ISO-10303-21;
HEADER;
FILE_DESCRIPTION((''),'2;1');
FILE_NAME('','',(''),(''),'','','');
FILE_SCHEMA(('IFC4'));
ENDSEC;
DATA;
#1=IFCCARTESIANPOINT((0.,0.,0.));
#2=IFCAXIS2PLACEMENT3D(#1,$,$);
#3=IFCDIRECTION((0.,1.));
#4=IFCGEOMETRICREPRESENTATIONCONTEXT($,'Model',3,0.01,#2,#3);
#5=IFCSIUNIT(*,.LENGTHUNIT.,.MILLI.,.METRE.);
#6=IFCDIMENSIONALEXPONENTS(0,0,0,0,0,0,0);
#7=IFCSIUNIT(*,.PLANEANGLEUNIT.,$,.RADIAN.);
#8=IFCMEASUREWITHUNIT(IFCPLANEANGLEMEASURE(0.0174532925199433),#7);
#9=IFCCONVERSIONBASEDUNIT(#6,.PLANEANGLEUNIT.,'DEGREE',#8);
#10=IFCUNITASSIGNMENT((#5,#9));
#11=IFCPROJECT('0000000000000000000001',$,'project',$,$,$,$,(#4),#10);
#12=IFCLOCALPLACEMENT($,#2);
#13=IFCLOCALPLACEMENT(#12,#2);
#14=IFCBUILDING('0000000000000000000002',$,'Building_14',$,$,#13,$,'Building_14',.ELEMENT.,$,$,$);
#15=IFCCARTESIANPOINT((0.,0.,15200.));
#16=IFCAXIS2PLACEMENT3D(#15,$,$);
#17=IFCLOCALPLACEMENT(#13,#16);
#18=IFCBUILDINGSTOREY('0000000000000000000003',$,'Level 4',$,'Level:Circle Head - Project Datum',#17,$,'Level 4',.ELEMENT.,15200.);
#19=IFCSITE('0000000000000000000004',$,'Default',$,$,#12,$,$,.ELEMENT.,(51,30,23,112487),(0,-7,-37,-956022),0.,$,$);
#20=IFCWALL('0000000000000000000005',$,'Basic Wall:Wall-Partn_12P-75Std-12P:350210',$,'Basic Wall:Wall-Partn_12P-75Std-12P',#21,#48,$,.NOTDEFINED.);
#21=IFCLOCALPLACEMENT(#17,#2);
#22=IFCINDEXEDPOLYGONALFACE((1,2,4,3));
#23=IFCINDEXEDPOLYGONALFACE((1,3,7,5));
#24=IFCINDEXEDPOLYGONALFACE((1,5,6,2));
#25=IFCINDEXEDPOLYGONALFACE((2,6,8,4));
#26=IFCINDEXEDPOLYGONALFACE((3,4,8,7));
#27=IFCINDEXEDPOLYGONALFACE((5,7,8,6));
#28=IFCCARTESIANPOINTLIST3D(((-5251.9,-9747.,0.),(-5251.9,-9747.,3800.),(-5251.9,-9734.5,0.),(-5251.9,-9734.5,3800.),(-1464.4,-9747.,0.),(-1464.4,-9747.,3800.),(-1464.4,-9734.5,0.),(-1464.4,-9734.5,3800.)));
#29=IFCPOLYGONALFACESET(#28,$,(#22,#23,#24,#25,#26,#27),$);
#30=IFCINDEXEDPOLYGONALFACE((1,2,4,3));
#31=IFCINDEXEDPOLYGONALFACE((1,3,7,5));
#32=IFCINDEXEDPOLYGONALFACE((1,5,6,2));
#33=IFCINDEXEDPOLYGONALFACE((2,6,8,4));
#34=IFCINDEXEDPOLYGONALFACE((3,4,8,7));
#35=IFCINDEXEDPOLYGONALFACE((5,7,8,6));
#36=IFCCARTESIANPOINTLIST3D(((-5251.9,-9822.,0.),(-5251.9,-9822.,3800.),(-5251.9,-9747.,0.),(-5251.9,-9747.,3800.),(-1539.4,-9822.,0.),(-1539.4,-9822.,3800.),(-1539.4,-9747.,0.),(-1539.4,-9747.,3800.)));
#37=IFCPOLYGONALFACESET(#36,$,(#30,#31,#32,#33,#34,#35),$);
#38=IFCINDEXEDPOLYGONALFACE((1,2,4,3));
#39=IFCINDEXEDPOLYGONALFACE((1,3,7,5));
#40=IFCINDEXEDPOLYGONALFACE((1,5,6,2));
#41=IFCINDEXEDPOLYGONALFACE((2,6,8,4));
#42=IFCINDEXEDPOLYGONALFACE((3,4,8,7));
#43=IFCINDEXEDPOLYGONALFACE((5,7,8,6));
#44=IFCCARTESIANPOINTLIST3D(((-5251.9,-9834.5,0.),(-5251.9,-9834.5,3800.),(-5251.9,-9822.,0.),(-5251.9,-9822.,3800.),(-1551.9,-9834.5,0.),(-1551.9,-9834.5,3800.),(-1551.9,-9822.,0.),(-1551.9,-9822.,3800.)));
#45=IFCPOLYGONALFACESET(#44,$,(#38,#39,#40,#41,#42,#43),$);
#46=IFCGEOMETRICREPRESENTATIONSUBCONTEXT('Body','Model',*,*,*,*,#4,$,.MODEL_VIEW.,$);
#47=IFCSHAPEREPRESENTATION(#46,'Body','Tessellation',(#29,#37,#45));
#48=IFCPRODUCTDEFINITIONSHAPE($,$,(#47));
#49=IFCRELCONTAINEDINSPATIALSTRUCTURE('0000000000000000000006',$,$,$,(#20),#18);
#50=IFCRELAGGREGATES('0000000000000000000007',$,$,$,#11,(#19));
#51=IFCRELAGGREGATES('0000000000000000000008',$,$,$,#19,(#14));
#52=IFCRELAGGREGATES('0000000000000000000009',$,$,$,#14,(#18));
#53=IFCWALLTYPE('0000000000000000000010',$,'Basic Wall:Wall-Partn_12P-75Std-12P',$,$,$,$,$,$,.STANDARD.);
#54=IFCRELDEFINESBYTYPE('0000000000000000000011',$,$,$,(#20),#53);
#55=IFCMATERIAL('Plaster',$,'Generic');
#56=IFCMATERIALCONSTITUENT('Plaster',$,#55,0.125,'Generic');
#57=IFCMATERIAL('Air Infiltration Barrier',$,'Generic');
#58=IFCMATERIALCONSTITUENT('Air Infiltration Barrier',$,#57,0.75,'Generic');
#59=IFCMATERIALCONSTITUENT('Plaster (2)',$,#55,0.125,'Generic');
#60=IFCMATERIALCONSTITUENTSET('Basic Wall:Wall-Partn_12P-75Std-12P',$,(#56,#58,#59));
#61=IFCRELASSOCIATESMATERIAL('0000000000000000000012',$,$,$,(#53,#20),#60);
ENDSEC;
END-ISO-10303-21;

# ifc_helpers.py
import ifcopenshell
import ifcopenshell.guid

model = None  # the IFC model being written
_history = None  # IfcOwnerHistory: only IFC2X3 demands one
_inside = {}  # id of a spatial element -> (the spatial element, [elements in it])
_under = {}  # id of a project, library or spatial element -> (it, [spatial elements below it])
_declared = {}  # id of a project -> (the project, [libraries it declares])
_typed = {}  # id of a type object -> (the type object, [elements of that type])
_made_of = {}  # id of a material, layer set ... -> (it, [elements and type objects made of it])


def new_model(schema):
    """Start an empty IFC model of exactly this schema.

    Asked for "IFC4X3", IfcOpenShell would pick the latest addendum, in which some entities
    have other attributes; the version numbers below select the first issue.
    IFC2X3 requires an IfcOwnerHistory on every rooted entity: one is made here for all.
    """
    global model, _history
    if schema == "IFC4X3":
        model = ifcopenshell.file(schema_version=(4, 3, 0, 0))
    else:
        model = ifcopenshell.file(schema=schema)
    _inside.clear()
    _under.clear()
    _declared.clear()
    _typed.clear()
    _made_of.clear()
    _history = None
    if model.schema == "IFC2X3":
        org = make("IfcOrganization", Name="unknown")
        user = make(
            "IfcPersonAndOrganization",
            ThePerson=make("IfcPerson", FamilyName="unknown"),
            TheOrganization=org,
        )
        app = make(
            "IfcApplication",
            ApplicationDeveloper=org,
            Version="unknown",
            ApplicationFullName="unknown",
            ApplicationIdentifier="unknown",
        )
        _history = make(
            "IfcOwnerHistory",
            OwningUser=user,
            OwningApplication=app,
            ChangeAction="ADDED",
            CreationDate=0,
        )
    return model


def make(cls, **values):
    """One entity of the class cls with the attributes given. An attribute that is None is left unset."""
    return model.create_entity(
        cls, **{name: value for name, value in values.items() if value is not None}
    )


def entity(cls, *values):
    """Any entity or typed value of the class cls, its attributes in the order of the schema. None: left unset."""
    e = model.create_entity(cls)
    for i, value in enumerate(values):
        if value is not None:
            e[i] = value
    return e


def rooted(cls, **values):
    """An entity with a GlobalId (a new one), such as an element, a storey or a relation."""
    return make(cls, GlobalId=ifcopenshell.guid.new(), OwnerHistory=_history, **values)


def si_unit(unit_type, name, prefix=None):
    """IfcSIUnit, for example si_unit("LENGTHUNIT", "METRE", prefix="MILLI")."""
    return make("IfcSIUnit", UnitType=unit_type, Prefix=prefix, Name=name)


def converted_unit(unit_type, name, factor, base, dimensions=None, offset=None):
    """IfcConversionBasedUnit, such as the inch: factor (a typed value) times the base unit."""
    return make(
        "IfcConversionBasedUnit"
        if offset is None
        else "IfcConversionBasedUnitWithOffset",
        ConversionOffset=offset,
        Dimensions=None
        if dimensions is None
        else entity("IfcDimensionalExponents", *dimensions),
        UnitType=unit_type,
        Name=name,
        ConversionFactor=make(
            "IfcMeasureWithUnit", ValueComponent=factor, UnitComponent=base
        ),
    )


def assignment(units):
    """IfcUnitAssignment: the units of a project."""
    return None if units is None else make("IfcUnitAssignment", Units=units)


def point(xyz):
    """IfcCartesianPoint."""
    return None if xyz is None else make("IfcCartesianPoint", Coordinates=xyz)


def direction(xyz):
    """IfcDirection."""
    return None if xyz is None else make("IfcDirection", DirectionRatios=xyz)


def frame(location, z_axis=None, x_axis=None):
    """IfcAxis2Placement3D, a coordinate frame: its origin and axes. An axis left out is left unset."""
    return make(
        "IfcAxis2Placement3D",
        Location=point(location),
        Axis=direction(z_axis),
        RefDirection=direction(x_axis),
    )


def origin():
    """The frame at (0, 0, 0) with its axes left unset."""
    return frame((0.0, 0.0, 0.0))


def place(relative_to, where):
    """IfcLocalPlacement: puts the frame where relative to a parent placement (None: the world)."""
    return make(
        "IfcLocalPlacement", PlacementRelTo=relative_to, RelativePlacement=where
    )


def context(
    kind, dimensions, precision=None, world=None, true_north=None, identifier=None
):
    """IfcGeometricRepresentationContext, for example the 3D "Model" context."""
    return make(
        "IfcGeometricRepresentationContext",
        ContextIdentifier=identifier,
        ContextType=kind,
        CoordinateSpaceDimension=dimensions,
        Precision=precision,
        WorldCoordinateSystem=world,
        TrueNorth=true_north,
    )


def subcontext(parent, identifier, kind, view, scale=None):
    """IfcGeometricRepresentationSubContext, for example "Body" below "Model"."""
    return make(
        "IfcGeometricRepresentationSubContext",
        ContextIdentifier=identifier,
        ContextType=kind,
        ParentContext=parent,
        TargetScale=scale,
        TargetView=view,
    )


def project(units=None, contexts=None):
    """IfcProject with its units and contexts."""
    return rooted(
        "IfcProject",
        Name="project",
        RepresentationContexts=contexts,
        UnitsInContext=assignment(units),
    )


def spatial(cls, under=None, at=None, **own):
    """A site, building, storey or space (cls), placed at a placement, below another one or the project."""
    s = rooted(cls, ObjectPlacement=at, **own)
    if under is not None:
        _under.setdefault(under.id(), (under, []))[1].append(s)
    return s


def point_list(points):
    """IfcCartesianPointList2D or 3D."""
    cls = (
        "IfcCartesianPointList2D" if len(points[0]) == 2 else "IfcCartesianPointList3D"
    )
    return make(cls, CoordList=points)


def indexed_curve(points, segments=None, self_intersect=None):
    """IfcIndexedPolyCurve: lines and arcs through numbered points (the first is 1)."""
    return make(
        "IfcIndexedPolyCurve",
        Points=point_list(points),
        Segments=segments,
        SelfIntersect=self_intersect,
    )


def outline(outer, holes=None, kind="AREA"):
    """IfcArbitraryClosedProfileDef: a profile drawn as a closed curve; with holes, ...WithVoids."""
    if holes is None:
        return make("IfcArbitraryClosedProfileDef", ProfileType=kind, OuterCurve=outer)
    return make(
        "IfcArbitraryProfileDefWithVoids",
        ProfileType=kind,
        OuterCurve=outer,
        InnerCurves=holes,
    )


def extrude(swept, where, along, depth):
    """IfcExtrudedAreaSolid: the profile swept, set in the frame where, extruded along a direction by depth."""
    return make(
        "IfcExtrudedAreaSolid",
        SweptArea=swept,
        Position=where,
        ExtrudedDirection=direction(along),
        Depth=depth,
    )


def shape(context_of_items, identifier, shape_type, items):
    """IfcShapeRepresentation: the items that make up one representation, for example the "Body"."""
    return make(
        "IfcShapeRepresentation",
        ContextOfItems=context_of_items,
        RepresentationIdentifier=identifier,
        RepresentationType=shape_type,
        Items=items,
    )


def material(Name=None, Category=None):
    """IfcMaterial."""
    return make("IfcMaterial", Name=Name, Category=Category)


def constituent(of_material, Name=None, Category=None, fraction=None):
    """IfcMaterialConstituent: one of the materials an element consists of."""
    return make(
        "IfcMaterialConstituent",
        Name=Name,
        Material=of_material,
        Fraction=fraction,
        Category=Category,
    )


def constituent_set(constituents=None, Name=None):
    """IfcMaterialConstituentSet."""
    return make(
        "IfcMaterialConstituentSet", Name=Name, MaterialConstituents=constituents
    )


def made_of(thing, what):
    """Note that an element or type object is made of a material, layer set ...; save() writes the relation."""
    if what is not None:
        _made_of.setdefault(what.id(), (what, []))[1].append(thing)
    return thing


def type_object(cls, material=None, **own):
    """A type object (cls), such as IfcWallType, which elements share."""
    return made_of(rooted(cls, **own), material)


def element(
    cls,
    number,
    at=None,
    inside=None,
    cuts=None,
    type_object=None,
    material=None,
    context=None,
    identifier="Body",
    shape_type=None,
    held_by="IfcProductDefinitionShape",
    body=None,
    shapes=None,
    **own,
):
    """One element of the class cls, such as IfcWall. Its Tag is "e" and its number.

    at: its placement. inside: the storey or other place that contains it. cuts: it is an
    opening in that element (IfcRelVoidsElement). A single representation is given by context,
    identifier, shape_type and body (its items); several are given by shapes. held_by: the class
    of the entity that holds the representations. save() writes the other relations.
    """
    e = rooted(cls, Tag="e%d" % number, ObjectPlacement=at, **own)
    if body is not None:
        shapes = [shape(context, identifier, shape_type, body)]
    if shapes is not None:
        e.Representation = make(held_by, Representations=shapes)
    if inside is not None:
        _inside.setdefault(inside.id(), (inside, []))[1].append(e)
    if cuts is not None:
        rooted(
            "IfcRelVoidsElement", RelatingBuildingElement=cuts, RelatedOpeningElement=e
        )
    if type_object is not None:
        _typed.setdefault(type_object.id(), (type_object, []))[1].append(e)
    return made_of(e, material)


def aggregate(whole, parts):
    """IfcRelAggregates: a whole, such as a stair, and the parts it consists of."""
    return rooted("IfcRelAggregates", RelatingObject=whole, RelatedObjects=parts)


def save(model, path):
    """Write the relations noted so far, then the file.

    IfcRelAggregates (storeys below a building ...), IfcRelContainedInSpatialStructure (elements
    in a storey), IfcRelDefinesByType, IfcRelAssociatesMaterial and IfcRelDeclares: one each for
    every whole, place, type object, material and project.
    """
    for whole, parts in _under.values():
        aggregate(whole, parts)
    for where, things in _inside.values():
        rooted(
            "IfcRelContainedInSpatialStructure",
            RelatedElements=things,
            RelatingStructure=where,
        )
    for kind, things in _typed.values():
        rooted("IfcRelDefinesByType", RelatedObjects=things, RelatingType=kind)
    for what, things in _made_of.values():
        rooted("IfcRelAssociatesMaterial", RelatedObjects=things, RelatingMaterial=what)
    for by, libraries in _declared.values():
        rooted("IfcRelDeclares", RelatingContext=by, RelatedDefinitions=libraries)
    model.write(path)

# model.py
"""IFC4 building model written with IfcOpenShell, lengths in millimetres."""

from ifc_helpers import new_model, entity, si_unit, converted_unit, direction, frame, origin, place, context, subcontext, project, spatial, indexed_curve, outline, extrude, material, constituent, constituent_set, type_object, element, save


model = new_model("IFC4")

# Units and contexts
model_context = context("Model", 3, precision=0.01, world=origin(), true_north=direction((0.0, 1.0)))
body_context = subcontext(model_context, "Body", "Model", "MODEL_VIEW")
ifc_project = project(units=[si_unit("LENGTHUNIT", "METRE", prefix="MILLI"), converted_unit("PLANEANGLEUNIT", "DEGREE", entity("IfcPlaneAngleMeasure", 0.0174532925199433), si_unit("PLANEANGLEUNIT", "RADIAN"), dimensions=[0, 0, 0, 0, 0, 0, 0])], contexts=[model_context])

# Site, building, storey
site_placement = place(None, origin())
site = spatial("IfcSite", under=ifc_project, at=site_placement, Name="Default", CompositionType="ELEMENT", RefLatitude=(51, 30, 23, 112487), RefLongitude=(0, -7, -37, -956022), RefElevation=0.0)
building_placement = place(site_placement, origin())
building = spatial("IfcBuilding", under=site, at=building_placement, Name="Building_14", LongName="Building_14", CompositionType="ELEMENT")
storey_placement = place(building_placement, frame((0.0, 0.0, 15200.0)))
storey = spatial("IfcBuildingStorey", under=building, at=storey_placement, Name="Level 4", ObjectType="Level:Circle Head - Project Datum", LongName="Level 4", CompositionType="ELEMENT", Elevation=15200.0)

# Shared definitions
ifc_material_1 = material(Name="Plaster", Category="Generic")
ifc_constituent_1 = constituent(ifc_material_1, Name="Plaster", Category="Generic", fraction=0.125)
ifc_material_2 = material(Name="Air Infiltration Barrier", Category="Generic")
ifc_constituent_2 = constituent(ifc_material_2, Name="Air Infiltration Barrier", Category="Generic", fraction=0.75)
ifc_constituent_3 = constituent(ifc_material_1, Name="Plaster (2)", Category="Generic", fraction=0.125)
ifc_constituent_set_1 = constituent_set(constituents=[ifc_constituent_1, ifc_constituent_2, ifc_constituent_3], Name="Basic Wall:Wall-Partn_12P-75Std-12P")
wall_type_1 = type_object("IfcWallType", Name="Basic Wall:Wall-Partn_12P-75Std-12P", PredefinedType="STANDARD", material=ifc_constituent_set_1)

# Wall
wall_1_placement = place(storey_placement, frame((-5251.9, -9784.5, 0.0)))
element("IfcWall", 1, at=wall_1_placement, inside=storey, type_object=wall_type_1, material=ifc_constituent_set_1, Name="Basic Wall:Wall-Partn_12P-75Std-12P:350210", ObjectType="Basic Wall:Wall-Partn_12P-75Std-12P", PredefinedType="NOTDEFINED", context=body_context, shape_type="SweptSolid", body=[
    extrude(outline(indexed_curve([(-6.3, -1893.8), (6.2, -1893.8), (6.3, 1893.8), (-6.2, 1893.8), (-6.3, -1893.8)], self_intersect=False)), frame((1893.8, 43.7, 0.0), z_axis=(0.0, 0.0, 1.0), x_axis=(0.0, -1.0, 0.0)), (0.0, 0.0, 1.0), 3800.0),
    extrude(outline(indexed_curve([(-1856.2, -37.5), (1856.2, -37.5), (1856.2, 37.5), (-1856.2, 37.5), (-1856.2, -37.5)], self_intersect=False)), frame((1856.2, 0.0, 0.0)), (0.0, 0.0, 1.0), 3800.0),
    extrude(outline(indexed_curve([(-6.3, -1850.0), (6.2, -1850.0), (6.3, 1850.0), (-6.2, 1850.0), (-6.3, -1850.0)], self_intersect=False)), frame((1850.0, -43.8, 0.0), z_axis=(0.0, 0.0, 1.0), x_axis=(0.0, 1.0, 0.0)), (0.0, 0.0, 1.0), 3800.0),
])

save(model, "model.ifc")
